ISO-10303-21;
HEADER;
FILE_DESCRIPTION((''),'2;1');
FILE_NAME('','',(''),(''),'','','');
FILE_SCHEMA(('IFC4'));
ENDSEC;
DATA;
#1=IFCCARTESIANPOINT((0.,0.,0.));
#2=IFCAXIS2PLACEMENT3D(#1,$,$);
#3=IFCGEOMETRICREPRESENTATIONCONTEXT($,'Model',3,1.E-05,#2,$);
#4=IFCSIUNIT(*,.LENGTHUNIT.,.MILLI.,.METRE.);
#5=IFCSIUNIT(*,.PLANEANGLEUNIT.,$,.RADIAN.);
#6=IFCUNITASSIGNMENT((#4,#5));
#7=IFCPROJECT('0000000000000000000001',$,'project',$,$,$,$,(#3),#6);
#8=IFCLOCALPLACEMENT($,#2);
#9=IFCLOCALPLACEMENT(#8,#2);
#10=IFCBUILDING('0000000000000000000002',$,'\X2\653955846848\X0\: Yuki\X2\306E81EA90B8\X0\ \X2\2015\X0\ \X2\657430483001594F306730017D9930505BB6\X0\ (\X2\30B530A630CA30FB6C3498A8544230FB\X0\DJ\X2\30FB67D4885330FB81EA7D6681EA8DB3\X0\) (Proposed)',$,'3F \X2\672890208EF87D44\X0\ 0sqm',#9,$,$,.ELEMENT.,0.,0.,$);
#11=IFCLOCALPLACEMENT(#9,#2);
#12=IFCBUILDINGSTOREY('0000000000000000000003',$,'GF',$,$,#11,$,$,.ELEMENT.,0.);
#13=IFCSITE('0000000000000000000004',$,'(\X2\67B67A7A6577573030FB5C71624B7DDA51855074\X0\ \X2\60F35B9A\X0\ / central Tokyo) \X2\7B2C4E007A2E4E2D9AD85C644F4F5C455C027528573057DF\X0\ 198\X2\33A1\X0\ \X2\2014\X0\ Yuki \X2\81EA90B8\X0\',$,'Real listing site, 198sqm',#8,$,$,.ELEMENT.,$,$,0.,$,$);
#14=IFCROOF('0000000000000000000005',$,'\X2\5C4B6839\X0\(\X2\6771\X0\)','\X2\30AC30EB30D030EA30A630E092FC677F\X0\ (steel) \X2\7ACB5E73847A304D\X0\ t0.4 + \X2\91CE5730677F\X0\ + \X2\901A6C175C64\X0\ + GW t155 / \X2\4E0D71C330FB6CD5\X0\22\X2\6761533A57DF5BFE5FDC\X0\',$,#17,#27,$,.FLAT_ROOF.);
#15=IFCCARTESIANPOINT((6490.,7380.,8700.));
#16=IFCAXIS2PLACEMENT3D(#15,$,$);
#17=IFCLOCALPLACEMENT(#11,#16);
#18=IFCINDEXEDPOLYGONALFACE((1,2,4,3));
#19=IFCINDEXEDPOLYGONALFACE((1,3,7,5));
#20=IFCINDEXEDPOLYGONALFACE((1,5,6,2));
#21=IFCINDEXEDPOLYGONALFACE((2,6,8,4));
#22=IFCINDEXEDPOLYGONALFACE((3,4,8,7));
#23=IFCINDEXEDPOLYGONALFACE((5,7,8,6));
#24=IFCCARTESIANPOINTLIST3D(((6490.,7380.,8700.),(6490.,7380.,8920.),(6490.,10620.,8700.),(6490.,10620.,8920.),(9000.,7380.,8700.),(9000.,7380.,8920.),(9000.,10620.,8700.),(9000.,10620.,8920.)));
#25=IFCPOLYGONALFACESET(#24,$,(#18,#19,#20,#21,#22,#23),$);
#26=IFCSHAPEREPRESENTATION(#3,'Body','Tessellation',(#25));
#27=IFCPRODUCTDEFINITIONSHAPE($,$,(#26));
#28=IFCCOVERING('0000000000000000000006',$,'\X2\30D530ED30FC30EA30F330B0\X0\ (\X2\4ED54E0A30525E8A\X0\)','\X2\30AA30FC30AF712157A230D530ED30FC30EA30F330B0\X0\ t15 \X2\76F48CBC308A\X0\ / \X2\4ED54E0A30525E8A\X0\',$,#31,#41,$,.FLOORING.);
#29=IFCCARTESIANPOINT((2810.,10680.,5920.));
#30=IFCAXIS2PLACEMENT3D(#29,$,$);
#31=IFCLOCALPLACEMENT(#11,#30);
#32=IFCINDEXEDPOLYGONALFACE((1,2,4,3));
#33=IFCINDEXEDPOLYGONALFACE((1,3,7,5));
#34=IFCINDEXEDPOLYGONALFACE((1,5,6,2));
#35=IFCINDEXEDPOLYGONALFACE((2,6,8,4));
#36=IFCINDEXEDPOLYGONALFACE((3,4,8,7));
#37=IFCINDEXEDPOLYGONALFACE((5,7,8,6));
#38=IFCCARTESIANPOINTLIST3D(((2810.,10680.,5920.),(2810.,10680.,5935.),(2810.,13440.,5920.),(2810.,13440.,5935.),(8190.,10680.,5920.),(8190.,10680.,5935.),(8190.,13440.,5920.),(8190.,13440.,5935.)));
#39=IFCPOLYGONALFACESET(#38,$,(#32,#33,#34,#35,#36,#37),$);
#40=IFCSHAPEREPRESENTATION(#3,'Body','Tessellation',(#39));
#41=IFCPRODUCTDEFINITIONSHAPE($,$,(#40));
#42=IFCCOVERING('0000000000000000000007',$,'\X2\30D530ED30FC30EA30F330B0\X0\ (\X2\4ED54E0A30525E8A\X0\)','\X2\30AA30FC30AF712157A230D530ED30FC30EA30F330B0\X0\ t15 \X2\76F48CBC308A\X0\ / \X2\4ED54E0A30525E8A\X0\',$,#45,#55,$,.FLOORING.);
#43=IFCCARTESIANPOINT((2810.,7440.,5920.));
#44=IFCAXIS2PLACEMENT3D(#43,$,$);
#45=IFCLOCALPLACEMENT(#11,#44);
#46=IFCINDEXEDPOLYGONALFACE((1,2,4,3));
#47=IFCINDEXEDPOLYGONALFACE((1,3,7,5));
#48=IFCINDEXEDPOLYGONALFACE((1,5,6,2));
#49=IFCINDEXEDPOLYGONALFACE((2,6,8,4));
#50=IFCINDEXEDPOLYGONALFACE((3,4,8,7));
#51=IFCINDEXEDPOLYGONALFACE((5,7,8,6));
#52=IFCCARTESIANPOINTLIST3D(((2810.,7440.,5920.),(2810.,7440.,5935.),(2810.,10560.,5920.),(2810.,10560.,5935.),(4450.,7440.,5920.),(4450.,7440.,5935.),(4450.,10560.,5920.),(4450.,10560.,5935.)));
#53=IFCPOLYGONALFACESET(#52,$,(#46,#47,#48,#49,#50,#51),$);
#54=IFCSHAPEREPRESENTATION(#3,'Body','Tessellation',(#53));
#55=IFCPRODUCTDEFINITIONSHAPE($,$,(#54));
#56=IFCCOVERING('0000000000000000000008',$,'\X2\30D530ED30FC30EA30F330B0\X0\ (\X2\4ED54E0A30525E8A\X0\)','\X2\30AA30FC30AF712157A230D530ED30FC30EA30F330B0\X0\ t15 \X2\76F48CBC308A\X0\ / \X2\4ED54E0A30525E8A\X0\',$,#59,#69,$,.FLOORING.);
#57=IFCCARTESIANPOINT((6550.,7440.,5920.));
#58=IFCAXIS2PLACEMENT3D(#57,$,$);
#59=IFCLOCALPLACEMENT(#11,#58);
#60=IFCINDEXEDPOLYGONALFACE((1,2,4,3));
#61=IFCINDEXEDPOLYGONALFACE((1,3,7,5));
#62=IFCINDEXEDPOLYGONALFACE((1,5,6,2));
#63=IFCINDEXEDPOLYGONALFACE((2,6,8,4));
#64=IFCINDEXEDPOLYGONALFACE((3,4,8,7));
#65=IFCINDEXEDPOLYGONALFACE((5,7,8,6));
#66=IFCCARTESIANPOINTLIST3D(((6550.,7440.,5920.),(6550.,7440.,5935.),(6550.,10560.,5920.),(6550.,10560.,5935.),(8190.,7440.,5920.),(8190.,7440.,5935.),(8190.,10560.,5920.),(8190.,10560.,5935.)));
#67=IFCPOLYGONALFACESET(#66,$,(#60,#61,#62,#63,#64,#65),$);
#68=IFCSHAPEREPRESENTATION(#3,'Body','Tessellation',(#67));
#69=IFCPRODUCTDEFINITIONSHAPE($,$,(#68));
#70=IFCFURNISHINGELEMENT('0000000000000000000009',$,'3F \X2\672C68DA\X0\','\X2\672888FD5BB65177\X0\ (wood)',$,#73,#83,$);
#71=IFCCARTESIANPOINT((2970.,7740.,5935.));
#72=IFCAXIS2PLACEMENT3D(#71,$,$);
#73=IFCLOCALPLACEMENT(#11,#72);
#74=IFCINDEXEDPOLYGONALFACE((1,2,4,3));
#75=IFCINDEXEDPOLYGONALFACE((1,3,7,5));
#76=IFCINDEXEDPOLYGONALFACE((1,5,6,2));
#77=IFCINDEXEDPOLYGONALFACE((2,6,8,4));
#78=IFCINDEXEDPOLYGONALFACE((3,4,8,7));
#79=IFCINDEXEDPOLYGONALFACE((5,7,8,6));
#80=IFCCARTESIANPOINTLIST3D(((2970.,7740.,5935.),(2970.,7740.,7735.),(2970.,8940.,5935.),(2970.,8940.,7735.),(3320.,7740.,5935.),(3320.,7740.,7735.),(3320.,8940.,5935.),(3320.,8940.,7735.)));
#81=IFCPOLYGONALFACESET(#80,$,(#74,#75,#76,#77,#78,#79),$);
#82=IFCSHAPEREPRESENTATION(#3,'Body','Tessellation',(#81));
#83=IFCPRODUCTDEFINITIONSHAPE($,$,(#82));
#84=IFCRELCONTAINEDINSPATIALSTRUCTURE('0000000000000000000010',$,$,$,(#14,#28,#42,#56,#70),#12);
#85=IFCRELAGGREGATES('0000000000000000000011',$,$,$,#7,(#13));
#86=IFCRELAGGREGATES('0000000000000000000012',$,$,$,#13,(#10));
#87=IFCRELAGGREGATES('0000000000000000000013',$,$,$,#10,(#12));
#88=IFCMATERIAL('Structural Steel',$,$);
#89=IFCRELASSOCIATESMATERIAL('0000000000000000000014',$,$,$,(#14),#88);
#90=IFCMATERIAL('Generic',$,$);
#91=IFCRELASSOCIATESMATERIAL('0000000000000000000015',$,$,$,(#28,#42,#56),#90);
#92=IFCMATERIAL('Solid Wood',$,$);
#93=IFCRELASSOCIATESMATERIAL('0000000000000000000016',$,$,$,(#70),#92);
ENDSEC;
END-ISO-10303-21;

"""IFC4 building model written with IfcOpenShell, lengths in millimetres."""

from ifc_helpers import new_model, si_unit, frame, frame_2d, origin, place, context, project, spatial, rectangle, extrude, material, element, save


model = new_model("IFC4")

# Units and contexts
model_context = context("Model", 3, precision=1e-05, world=origin())
ifc_project = project(units=[si_unit("LENGTHUNIT", "METRE", prefix="MILLI"), si_unit("PLANEANGLEUNIT", "RADIAN")], contexts=[model_context])

# Site, building, storey
site_placement = place(None, origin())
site = spatial("IfcSite", under=ifc_project, at=site_placement, Name="(架空敷地・山手線内側 想定 / central Tokyo) 第一種中高層住居専用地域 198㎡ — Yuki 自邸", ObjectType="Real listing site, 198sqm", CompositionType="ELEMENT", RefElevation=0.0)
building_placement = place(site_placement, origin())
building = spatial("IfcBuilding", under=site, at=building_placement, Name="改善案: Yukiの自邸 ― 整え、奏で、継ぐ家 (サウナ・水風呂・DJ・柔術・自給自足) (Proposed)", ObjectType="3F 木造軸組 0sqm", CompositionType="ELEMENT", ElevationOfRefHeight=0.0, ElevationOfTerrain=0.0)
storey_placement = place(building_placement, origin())
storey = spatial("IfcBuildingStorey", under=building, at=storey_placement, Name="GF", CompositionType="ELEMENT", Elevation=0.0)

# Shared definitions
ifc_material_1 = material(Name="Solid Wood")

# Shared definitions
ifc_material_2 = material(Name="Generic")

# Roof
ifc_material_3 = material(Name="Structural Steel")
roof_1_placement = place(storey_placement, frame((6490.0, 7380.0, 8700.0)))
element("IfcRoof", 1, at=roof_1_placement, inside=storey, material=ifc_material_3, Name="屋根(東)", Description="ガルバリウム鋼板 (steel) 立平葺き t0.4 + 野地板 + 通気層 + GW t155 / 不燃・法22条区域対応", PredefinedType="FLAT_ROOF", context=model_context, shape_type="SweptSolid", body=[
    extrude(rectangle(XDim=2510.0, YDim=3240.0, at=frame_2d((1255.0, 1620.0))), frame((6490.0, 7380.0, 8700.0)), (0.0, 0.0, 1.0), 220.0),
])

# Coverings
covering_1_placement = place(storey_placement, frame((2810.0, 10680.0, 5920.0)))
element("IfcCovering", 2, at=covering_1_placement, inside=storey, material=ifc_material_2, Name="フローリング (仕上げ床)", Description="オーク無垢フローリング t15 直貼り / 仕上げ床", PredefinedType="FLOORING", context=model_context, shape_type="SweptSolid", body=[
    extrude(rectangle(XDim=5380.0, YDim=2760.0, at=frame_2d((2690.0, 1380.0))), frame((2810.0, 10680.0, 5920.0)), (0.0, 0.0, 1.0), 15.0),
])
covering_2_placement = place(storey_placement, frame((2810.0, 7440.0, 5920.0)))
element("IfcCovering", 3, at=covering_2_placement, inside=storey, material=ifc_material_2, Name="フローリング (仕上げ床)", Description="オーク無垢フローリング t15 直貼り / 仕上げ床", PredefinedType="FLOORING", context=model_context, shape_type="SweptSolid", body=[
    extrude(rectangle(XDim=1640.0, YDim=3120.0, at=frame_2d((820.0, 1560.0))), frame((2810.0, 7440.0, 5920.0)), (0.0, 0.0, 1.0), 15.0),
])
covering_3_placement = place(storey_placement, frame((6550.0, 7440.0, 5920.0)))
element("IfcCovering", 4, at=covering_3_placement, inside=storey, material=ifc_material_2, Name="フローリング (仕上げ床)", Description="オーク無垢フローリング t15 直貼り / 仕上げ床", PredefinedType="FLOORING", context=model_context, shape_type="SweptSolid", body=[
    extrude(rectangle(XDim=1640.0, YDim=3120.0, at=frame_2d((820.0, 1560.0))), frame((6550.0, 7440.0, 5920.0)), (0.0, 0.0, 1.0), 15.0),
])

# Furnishing element
furnishing_placement = place(storey_placement, frame((2970.0, 7740.0, 5935.0)))
element("IfcFurnishingElement", 5, at=furnishing_placement, inside=storey, material=ifc_material_1, Name="3F 本棚", Description="木製家具 (wood)", context=model_context, shape_type="SweptSolid", body=[
    extrude(rectangle(XDim=350.0, YDim=1200.0, at=frame_2d((175.0, 600.0))), frame((2970.0, 7740.0, 5935.0)), (0.0, 0.0, 1.0), 1800.0),
])

save(model, "model.ifc")
